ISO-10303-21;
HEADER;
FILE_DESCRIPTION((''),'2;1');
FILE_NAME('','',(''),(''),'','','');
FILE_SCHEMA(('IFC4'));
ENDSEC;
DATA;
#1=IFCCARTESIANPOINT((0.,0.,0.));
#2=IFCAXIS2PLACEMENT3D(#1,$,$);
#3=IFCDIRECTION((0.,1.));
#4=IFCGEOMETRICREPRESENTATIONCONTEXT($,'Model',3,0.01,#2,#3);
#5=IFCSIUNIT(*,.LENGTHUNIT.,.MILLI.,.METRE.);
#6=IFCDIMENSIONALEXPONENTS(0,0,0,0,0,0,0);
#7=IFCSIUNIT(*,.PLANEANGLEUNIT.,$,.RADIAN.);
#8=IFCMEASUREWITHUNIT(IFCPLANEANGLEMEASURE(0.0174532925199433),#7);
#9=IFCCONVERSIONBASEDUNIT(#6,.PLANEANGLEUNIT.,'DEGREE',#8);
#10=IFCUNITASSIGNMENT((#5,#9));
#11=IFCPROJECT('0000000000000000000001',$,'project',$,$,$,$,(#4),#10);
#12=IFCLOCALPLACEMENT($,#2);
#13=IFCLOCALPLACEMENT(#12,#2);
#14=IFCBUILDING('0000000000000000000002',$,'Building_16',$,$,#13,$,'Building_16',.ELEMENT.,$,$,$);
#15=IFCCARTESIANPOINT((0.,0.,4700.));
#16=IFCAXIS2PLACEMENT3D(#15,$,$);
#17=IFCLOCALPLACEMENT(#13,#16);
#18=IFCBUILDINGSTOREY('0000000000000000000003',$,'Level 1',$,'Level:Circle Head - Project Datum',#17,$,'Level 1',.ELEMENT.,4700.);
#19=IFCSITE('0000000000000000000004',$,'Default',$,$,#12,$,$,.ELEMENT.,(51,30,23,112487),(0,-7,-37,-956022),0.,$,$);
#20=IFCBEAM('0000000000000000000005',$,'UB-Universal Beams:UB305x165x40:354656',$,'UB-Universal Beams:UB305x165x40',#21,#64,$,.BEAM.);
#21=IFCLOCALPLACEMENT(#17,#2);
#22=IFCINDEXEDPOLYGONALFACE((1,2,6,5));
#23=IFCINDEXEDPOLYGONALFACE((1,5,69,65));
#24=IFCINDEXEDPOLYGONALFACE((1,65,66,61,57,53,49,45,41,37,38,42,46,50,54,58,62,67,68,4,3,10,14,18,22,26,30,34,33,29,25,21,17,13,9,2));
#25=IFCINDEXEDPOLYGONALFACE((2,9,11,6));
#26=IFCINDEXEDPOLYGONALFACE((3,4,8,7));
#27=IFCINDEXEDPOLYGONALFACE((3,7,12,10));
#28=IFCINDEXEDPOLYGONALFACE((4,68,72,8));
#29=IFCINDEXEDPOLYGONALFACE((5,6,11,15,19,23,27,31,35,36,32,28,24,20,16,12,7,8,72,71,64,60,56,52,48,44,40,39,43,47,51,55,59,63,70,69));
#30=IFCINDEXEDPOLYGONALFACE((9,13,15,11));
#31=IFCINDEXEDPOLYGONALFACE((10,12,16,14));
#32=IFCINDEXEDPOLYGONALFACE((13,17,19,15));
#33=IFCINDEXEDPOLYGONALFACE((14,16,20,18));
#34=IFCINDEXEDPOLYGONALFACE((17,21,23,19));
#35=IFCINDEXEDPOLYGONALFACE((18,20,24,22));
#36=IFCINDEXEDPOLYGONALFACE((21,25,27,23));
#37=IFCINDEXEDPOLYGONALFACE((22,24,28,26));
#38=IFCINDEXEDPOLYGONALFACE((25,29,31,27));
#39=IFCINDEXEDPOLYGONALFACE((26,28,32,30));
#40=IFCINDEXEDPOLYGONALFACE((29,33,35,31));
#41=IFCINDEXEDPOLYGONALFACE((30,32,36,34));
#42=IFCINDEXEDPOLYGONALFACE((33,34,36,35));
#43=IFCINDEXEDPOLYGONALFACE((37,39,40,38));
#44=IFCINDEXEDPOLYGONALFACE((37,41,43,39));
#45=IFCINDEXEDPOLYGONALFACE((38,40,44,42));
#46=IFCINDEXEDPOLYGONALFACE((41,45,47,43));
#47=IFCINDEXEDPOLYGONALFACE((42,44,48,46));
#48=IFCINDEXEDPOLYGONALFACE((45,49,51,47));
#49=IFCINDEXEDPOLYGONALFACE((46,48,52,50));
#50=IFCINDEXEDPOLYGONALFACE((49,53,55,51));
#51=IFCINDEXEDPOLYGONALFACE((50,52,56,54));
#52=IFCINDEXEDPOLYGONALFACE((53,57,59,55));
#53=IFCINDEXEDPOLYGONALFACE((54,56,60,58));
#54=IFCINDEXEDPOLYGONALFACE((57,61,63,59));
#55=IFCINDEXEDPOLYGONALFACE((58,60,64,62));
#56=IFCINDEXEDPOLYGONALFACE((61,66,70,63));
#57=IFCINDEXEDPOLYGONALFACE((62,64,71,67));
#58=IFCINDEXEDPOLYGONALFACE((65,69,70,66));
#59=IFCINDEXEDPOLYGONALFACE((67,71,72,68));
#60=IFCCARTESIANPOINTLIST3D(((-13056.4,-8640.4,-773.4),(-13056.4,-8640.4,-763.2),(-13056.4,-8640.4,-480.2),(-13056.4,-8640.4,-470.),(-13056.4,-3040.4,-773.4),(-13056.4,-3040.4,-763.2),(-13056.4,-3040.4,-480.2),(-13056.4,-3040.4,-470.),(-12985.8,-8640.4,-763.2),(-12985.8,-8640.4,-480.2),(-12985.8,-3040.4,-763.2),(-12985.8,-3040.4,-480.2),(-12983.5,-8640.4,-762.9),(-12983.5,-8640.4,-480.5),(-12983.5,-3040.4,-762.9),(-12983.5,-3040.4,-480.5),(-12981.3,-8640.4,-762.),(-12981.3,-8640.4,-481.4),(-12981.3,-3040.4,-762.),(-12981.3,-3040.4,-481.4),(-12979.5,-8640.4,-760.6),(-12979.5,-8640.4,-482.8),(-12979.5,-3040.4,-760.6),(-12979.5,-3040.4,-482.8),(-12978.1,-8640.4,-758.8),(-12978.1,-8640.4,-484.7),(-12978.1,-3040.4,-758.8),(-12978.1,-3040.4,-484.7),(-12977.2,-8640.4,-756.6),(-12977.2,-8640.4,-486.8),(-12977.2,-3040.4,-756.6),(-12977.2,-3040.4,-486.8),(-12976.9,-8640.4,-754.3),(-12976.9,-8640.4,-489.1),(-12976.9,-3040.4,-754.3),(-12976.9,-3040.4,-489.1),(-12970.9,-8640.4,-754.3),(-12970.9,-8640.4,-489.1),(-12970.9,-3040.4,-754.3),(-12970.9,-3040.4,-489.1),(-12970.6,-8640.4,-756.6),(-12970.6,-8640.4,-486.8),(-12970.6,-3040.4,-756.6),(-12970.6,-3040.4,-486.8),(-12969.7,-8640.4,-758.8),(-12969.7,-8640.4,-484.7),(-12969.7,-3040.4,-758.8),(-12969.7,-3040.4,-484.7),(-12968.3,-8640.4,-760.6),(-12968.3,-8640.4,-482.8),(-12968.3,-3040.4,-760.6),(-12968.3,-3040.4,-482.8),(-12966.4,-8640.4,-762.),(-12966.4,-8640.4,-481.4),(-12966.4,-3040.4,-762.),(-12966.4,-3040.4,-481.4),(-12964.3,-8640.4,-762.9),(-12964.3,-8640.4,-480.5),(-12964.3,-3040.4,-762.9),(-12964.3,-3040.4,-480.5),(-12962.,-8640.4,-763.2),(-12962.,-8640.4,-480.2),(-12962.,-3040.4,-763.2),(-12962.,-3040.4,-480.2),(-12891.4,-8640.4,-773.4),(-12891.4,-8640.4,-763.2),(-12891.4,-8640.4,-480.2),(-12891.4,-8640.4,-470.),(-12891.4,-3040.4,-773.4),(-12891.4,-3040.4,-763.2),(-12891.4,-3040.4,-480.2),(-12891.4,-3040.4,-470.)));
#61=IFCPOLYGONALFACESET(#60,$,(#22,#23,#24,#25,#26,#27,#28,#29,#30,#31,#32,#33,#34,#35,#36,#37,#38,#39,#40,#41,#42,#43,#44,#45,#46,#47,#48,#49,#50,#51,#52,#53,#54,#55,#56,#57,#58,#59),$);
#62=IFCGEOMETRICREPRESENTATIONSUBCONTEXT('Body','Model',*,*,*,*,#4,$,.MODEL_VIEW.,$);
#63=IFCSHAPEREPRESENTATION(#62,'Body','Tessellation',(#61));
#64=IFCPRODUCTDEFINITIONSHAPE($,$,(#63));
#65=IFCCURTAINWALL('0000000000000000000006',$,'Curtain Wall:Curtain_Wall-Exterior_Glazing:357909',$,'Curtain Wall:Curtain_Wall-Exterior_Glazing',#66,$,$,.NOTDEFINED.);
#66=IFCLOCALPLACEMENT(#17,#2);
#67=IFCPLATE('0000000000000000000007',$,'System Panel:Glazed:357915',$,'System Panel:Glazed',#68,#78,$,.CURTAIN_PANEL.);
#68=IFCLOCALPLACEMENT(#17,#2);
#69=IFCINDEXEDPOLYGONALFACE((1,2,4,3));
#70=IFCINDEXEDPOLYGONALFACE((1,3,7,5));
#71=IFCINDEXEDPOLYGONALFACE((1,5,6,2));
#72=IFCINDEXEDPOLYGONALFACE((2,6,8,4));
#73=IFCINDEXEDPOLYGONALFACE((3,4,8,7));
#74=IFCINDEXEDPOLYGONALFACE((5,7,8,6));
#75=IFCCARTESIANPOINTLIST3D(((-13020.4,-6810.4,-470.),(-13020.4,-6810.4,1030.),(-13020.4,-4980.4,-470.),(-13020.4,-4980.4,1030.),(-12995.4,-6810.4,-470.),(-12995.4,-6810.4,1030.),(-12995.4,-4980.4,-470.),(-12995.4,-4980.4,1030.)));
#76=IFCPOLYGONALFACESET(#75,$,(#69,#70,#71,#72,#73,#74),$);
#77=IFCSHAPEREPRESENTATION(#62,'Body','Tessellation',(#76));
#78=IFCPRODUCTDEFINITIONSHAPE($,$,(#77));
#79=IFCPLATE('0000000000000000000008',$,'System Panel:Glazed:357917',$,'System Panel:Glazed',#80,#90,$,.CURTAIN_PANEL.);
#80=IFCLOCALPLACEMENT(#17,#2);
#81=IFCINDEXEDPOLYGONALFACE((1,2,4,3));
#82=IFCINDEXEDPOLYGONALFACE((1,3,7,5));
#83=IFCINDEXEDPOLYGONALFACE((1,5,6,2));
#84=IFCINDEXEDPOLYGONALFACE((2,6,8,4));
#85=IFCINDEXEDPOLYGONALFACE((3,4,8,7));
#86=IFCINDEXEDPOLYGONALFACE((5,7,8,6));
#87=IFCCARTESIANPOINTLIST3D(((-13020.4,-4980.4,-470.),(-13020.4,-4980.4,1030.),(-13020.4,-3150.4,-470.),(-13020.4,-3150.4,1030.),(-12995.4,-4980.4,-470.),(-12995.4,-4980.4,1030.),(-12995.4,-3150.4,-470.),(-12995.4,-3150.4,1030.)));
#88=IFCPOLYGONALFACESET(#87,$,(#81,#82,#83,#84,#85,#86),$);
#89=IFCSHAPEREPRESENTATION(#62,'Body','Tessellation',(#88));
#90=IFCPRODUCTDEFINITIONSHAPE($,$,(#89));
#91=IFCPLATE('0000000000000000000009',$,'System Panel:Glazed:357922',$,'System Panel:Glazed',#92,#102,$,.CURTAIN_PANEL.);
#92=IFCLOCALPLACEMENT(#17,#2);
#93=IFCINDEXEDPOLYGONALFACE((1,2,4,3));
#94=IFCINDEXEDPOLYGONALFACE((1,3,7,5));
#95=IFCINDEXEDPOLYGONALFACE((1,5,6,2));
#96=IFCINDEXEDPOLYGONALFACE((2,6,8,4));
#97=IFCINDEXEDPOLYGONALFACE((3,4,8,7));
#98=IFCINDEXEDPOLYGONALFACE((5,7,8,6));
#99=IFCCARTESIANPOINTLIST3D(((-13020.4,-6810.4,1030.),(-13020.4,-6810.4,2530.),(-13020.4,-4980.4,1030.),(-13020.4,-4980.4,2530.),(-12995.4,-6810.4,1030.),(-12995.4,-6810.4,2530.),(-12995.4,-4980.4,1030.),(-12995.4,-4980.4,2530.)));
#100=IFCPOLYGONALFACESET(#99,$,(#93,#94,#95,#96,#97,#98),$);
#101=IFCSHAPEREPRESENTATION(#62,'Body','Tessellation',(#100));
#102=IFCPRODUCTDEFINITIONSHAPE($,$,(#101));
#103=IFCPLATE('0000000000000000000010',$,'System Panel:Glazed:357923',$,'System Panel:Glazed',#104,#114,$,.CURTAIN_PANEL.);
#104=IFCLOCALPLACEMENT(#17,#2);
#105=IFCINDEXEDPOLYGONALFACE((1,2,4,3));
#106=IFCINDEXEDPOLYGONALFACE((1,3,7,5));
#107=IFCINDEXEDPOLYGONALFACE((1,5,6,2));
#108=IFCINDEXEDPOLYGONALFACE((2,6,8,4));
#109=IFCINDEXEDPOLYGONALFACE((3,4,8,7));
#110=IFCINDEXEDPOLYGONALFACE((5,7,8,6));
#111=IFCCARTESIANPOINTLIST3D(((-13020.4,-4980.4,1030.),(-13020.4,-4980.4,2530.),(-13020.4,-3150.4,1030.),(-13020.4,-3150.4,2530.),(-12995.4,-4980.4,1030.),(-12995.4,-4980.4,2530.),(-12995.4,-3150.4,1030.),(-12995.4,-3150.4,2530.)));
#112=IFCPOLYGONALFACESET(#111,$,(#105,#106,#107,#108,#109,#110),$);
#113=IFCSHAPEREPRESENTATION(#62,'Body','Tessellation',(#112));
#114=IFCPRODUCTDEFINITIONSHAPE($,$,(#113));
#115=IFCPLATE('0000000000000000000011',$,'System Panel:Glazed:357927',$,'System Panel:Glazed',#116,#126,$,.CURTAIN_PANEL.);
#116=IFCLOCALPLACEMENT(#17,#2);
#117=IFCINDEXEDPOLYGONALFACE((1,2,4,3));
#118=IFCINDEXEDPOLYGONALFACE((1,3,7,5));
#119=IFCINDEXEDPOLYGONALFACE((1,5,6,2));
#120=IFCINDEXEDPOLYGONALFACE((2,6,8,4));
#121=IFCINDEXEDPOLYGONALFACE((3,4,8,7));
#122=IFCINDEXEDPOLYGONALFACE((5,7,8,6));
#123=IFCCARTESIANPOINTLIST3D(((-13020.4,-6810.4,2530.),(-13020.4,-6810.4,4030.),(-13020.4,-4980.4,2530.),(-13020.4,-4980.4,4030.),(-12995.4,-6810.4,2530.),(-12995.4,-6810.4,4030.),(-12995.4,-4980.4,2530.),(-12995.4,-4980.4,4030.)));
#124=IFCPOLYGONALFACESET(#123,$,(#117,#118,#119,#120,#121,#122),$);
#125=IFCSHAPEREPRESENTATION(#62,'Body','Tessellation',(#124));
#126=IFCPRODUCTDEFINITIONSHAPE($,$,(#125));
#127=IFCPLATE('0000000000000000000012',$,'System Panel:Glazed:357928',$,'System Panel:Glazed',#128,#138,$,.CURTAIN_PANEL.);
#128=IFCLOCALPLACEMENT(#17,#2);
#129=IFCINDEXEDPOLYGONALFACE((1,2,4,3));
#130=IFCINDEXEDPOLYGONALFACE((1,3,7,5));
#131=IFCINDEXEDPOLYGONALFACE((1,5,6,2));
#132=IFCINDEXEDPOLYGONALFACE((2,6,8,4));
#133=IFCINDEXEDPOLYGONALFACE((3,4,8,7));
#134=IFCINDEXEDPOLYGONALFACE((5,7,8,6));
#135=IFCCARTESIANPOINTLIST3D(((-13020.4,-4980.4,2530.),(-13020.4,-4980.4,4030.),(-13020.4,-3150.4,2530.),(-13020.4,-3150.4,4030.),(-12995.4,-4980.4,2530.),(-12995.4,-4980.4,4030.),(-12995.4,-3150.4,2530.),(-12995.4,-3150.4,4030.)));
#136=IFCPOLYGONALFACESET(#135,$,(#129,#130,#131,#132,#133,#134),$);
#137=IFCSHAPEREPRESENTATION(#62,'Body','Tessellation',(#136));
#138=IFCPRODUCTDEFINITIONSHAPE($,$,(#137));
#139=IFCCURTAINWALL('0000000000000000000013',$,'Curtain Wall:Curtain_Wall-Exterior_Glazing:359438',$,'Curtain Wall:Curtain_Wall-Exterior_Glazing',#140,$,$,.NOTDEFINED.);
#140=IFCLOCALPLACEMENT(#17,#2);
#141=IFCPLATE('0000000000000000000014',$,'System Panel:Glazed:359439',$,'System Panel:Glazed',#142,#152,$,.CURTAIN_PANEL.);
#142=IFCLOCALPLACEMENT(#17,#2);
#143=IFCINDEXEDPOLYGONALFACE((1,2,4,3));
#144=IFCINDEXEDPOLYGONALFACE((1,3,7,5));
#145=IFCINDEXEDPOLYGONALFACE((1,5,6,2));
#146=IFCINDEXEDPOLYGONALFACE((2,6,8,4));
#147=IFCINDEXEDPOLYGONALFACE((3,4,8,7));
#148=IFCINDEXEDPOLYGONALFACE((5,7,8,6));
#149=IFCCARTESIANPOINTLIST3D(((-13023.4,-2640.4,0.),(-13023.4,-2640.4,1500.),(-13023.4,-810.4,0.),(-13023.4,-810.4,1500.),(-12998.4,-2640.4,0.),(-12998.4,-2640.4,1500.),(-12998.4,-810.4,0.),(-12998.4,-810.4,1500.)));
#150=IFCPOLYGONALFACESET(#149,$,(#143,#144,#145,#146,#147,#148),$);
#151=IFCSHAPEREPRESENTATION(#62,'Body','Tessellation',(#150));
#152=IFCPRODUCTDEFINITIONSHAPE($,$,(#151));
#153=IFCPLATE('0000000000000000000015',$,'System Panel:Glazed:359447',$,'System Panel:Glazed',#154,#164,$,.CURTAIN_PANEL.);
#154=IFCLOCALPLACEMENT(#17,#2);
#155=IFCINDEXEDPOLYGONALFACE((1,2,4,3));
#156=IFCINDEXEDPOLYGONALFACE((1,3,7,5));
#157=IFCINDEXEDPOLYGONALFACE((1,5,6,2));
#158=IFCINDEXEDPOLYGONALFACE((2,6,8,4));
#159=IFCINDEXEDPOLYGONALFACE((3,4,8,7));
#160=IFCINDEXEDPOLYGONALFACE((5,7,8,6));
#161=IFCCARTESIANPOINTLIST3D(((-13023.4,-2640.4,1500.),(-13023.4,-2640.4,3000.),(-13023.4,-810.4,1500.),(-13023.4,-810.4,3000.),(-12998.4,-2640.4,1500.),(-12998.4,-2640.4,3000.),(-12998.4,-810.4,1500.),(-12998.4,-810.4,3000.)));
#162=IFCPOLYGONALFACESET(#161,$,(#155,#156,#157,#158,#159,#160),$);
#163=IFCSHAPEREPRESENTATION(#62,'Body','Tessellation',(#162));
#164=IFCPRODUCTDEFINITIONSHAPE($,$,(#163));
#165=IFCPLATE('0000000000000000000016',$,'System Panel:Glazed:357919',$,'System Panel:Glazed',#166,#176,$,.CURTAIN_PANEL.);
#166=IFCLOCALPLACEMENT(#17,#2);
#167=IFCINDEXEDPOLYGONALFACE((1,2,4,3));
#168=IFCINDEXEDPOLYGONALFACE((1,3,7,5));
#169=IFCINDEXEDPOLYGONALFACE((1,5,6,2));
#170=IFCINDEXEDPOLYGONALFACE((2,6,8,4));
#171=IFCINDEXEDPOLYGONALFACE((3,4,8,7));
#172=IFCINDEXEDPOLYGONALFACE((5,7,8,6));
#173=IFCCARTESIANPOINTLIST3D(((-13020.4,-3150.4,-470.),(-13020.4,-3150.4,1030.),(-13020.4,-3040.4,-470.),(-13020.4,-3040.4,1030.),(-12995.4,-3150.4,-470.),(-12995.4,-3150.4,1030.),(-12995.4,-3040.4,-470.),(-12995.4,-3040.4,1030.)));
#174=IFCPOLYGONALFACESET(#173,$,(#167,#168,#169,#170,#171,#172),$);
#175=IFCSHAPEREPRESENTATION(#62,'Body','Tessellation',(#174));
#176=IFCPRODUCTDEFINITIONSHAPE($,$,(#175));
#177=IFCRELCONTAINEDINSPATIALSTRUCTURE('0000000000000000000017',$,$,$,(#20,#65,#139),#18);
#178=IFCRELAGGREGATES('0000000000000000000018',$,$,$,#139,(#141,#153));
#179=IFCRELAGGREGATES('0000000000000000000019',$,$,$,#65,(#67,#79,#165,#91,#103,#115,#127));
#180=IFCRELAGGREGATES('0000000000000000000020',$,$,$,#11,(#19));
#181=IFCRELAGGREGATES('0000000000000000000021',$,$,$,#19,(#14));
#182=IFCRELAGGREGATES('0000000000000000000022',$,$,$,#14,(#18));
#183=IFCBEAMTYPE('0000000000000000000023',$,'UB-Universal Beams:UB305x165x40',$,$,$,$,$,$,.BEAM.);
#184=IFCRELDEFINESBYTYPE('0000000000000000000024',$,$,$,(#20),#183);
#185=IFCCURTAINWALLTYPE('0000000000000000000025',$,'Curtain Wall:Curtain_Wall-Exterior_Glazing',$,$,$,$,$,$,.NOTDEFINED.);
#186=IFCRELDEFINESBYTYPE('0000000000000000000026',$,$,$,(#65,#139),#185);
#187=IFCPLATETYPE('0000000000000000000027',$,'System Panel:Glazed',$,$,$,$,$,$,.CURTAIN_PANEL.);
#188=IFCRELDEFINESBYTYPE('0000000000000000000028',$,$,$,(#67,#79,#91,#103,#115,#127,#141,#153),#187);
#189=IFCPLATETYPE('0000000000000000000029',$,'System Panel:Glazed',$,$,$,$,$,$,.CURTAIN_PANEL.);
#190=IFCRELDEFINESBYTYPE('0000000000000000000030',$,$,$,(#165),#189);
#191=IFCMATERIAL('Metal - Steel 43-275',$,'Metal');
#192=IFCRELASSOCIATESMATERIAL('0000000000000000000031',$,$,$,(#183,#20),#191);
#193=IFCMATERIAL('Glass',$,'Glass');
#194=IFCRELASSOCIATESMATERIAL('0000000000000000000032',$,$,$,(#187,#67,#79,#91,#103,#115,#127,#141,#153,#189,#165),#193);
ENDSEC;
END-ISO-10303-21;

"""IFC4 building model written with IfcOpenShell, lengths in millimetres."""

from ifc_helpers import new_model, entity, si_unit, converted_unit, direction, frame, origin, place, context, subcontext, project, spatial, line, arc, indexed_curve, outline, extrude, source, transform, mapped, material, type_object, type_shapes, element, aggregate, save


model = new_model("IFC4")

# Units and contexts
model_context = context("Model", 3, precision=0.01, world=origin(), true_north=direction((0.0, 1.0)))
body_context = subcontext(model_context, "Body", "Model", "MODEL_VIEW")
ifc_project = project(units=[si_unit("LENGTHUNIT", "METRE", prefix="MILLI"), converted_unit("PLANEANGLEUNIT", "DEGREE", entity("IfcPlaneAngleMeasure", 0.0174532925199433), si_unit("PLANEANGLEUNIT", "RADIAN"), dimensions=[0, 0, 0, 0, 0, 0, 0])], contexts=[model_context])

# Site, building, storey
site_placement = place(None, origin())
site = spatial("IfcSite", under=ifc_project, at=site_placement, Name="Default", CompositionType="ELEMENT", RefLatitude=(51, 30, 23, 112487), RefLongitude=(0, -7, -37, -956022), RefElevation=0.0)
building_placement = place(site_placement, origin())
building = spatial("IfcBuilding", under=site, at=building_placement, Name="Building_16", LongName="Building_16", CompositionType="ELEMENT")
storey_placement = place(building_placement, frame((0.0, 0.0, 4700.0)))
storey = spatial("IfcBuildingStorey", under=building, at=storey_placement, Name="Level 1", ObjectType="Level:Circle Head - Project Datum", LongName="Level 1", CompositionType="ELEMENT", Elevation=4700.0)

# Beam
ifc_material_1 = material(Name="Metal - Steel 43-275", Category="Metal")
beam_type = type_object("IfcBeamType", Name="UB-Universal Beams:UB305x165x40", PredefinedType="BEAM", material=ifc_material_1)
shared_shape_1 = source(origin(), body_context, "Body", "SweptSolid", [
    extrude(outline(indexed_curve([(-82.5, -141.5), (-82.5, -151.7), (82.5, -151.7), (82.5, -141.5), (11.9, -141.5), (5.6, -138.9), (3.0, -132.6), (3.0, 132.6), (5.6, 138.9), (11.9, 141.5), (82.5, 141.5), (82.5, 151.7), (-82.5, 151.7), (-82.5, 141.5), (-11.9, 141.5), (-5.6, 138.9), (-3.0, 132.6), (-3.0, -132.6), (-5.6, -138.9), (-11.9, -141.5)], segments=[line(1, 2, 3, 4, 5), arc(5, 6, 7), line(7, 8), arc(8, 9, 10), line(10, 11, 12, 13, 14, 15), arc(15, 16, 17), line(17, 18), arc(18, 19, 20), line(20, 1)], self_intersect=False)), frame((-2800.0, 0.0, 0.0), z_axis=(-1.0, 0.0, 0.0), x_axis=(0.0, -1.0, 0.0)), (0.0, 0.0, -1.0), 5600.0),
])
type_shapes(beam_type, [shared_shape_1])
beam_placement = place(storey_placement, frame((-12973.9, -5840.4, -621.7), z_axis=(0.0, 0.0, 1.0), x_axis=(0.0, 1.0, 0.0)))
element("IfcBeam", 1, at=beam_placement, inside=storey, type_object=beam_type, material=ifc_material_1, Name="UB-Universal Beams:UB305x165x40:354656", ObjectType="UB-Universal Beams:UB305x165x40", PredefinedType="BEAM", context=body_context, shape_type="MappedRepresentation", body=[
    mapped(shared_shape_1, transform((0.0, 0.0, 0.0), scale=1.0)),
])

# Curtain walls, plates
curtain_wall_type = type_object("IfcCurtainWallType", Name="Curtain Wall:Curtain_Wall-Exterior_Glazing", PredefinedType="NOTDEFINED")
curtain_wall_1_placement = place(storey_placement, frame((0.0, 0.0, -4700.0)))
curtain_wall_1 = element("IfcCurtainWall", 2, at=curtain_wall_1_placement, inside=storey, type_object=curtain_wall_type, Name="Curtain Wall:Curtain_Wall-Exterior_Glazing:357909", ObjectType="Curtain Wall:Curtain_Wall-Exterior_Glazing", PredefinedType="NOTDEFINED")
ifc_material_2 = material(Name="Glass", Category="Glass")
plate_type_1 = type_object("IfcPlateType", Name="System Panel:Glazed", PredefinedType="CURTAIN_PANEL", material=ifc_material_2)
shared_shape_2 = source(origin(), body_context, "Body", "SweptSolid", [
    extrude(outline(indexed_curve([(-12.5, -915.0), (12.5, -915.0), (12.5, 915.0), (-12.5, 915.0), (-12.5, -915.0)], self_intersect=False)), frame((0.0, 37.0, 0.0), z_axis=(0.0, 0.0, 1.0), x_axis=(0.0, 1.0, 0.0)), (0.0, 0.0, 1.0), 1500.0),
])
type_shapes(plate_type_1, [shared_shape_2])
plate_1_placement = place(curtain_wall_1_placement, frame((-12970.9, -5895.4, 4230.0), z_axis=(0.0, 0.0, 1.0), x_axis=(0.0, 1.0, 0.0)))
plate_1 = element("IfcPlate", 3, at=plate_1_placement, type_object=plate_type_1, material=ifc_material_2, Name="System Panel:Glazed:357915", ObjectType="System Panel:Glazed", PredefinedType="CURTAIN_PANEL", context=body_context, shape_type="MappedRepresentation", body=[
    mapped(shared_shape_2, transform((0.0, 0.0, 0.0), scale=1.0)),
])
plate_2_placement = place(curtain_wall_1_placement, frame((-12970.9, -4065.4, 4230.0), z_axis=(0.0, 0.0, 1.0), x_axis=(0.0, 1.0, 0.0)))
plate_2 = element("IfcPlate", 4, at=plate_2_placement, type_object=plate_type_1, material=ifc_material_2, Name="System Panel:Glazed:357917", ObjectType="System Panel:Glazed", PredefinedType="CURTAIN_PANEL", context=body_context, shape_type="MappedRepresentation", body=[
    mapped(shared_shape_2, transform((0.0, 0.0, 0.0), scale=1.0)),
])
plate_3_placement = place(curtain_wall_1_placement, frame((-12970.9, -5895.4, 5730.0), z_axis=(0.0, 0.0, 1.0), x_axis=(0.0, 1.0, 0.0)))
plate_3 = element("IfcPlate", 5, at=plate_3_placement, type_object=plate_type_1, material=ifc_material_2, Name="System Panel:Glazed:357922", ObjectType="System Panel:Glazed", PredefinedType="CURTAIN_PANEL", context=body_context, shape_type="MappedRepresentation", body=[
    mapped(shared_shape_2, transform((0.0, 0.0, 0.0), scale=1.0)),
])
plate_4_placement = place(curtain_wall_1_placement, frame((-12970.9, -4065.4, 5730.0), z_axis=(0.0, 0.0, 1.0), x_axis=(0.0, 1.0, 0.0)))
plate_4 = element("IfcPlate", 6, at=plate_4_placement, type_object=plate_type_1, material=ifc_material_2, Name="System Panel:Glazed:357923", ObjectType="System Panel:Glazed", PredefinedType="CURTAIN_PANEL", context=body_context, shape_type="MappedRepresentation", body=[
    mapped(shared_shape_2, transform((0.0, 0.0, 0.0), scale=1.0)),
])
plate_5_placement = place(curtain_wall_1_placement, frame((-12970.9, -5895.4, 7230.0), z_axis=(0.0, 0.0, 1.0), x_axis=(0.0, 1.0, 0.0)))
plate_5 = element("IfcPlate", 7, at=plate_5_placement, type_object=plate_type_1, material=ifc_material_2, Name="System Panel:Glazed:357927", ObjectType="System Panel:Glazed", PredefinedType="CURTAIN_PANEL", context=body_context, shape_type="MappedRepresentation", body=[
    mapped(shared_shape_2, transform((0.0, 0.0, 0.0), scale=1.0)),
])
plate_6_placement = place(curtain_wall_1_placement, frame((-12970.9, -4065.4, 7230.0), z_axis=(0.0, 0.0, 1.0), x_axis=(0.0, 1.0, 0.0)))
plate_6 = element("IfcPlate", 8, at=plate_6_placement, type_object=plate_type_1, material=ifc_material_2, Name="System Panel:Glazed:357928", ObjectType="System Panel:Glazed", PredefinedType="CURTAIN_PANEL", context=body_context, shape_type="MappedRepresentation", body=[
    mapped(shared_shape_2, transform((0.0, 0.0, 0.0), scale=1.0)),
])
curtain_wall_2_placement = place(storey_placement, frame((0.0, 0.0, -4700.0)))
curtain_wall_2 = element("IfcCurtainWall", 9, at=curtain_wall_2_placement, inside=storey, type_object=curtain_wall_type, Name="Curtain Wall:Curtain_Wall-Exterior_Glazing:359438", ObjectType="Curtain Wall:Curtain_Wall-Exterior_Glazing", PredefinedType="NOTDEFINED")
plate_7_placement = place(curtain_wall_2_placement, frame((-12973.9, -1725.4, 4700.0), z_axis=(0.0, 0.0, 1.0), x_axis=(0.0, 1.0, 0.0)))
plate_7 = element("IfcPlate", 10, at=plate_7_placement, type_object=plate_type_1, material=ifc_material_2, Name="System Panel:Glazed:359439", ObjectType="System Panel:Glazed", PredefinedType="CURTAIN_PANEL", context=body_context, shape_type="MappedRepresentation", body=[
    mapped(shared_shape_2, transform((0.0, 0.0, 0.0), scale=1.0)),
])
plate_8_placement = place(curtain_wall_2_placement, frame((-12973.9, -1725.4, 6200.0), z_axis=(0.0, 0.0, 1.0), x_axis=(0.0, 1.0, 0.0)))
plate_8 = element("IfcPlate", 11, at=plate_8_placement, type_object=plate_type_1, material=ifc_material_2, Name="System Panel:Glazed:359447", ObjectType="System Panel:Glazed", PredefinedType="CURTAIN_PANEL", context=body_context, shape_type="MappedRepresentation", body=[
    mapped(shared_shape_2, transform((0.0, 0.0, 0.0), scale=1.0)),
])

# Plate
plate_type_2 = type_object("IfcPlateType", Name="System Panel:Glazed", PredefinedType="CURTAIN_PANEL", material=ifc_material_2)
shared_shape_3 = source(origin(), body_context, "Body", "SweptSolid", [
    extrude(outline(indexed_curve([(-12.5, -55.0), (12.5, -55.0), (12.5, 55.0), (-12.5, 55.0), (-12.5, -55.0)], self_intersect=False)), frame((0.0, 37.0, 0.0), z_axis=(0.0, 0.0, 1.0), x_axis=(0.0, 1.0, 0.0)), (0.0, 0.0, 1.0), 1500.0),
])
type_shapes(plate_type_2, [shared_shape_3])
plate_9_placement = place(curtain_wall_1_placement, frame((-12970.9, -3095.4, 4230.0), z_axis=(0.0, 0.0, 1.0), x_axis=(0.0, 1.0, 0.0)))
plate_9 = element("IfcPlate", 12, at=plate_9_placement, type_object=plate_type_2, material=ifc_material_2, Name="System Panel:Glazed:357919", ObjectType="System Panel:Glazed", PredefinedType="CURTAIN_PANEL", context=body_context, shape_type="MappedRepresentation", body=[
    mapped(shared_shape_3, transform((0.0, 0.0, 0.0), scale=1.0)),
])
aggregate(curtain_wall_2, [plate_7, plate_8])
aggregate(curtain_wall_1, [plate_1, plate_2, plate_9, plate_3, plate_4, plate_5, plate_6])

save(model, "model.ifc")
